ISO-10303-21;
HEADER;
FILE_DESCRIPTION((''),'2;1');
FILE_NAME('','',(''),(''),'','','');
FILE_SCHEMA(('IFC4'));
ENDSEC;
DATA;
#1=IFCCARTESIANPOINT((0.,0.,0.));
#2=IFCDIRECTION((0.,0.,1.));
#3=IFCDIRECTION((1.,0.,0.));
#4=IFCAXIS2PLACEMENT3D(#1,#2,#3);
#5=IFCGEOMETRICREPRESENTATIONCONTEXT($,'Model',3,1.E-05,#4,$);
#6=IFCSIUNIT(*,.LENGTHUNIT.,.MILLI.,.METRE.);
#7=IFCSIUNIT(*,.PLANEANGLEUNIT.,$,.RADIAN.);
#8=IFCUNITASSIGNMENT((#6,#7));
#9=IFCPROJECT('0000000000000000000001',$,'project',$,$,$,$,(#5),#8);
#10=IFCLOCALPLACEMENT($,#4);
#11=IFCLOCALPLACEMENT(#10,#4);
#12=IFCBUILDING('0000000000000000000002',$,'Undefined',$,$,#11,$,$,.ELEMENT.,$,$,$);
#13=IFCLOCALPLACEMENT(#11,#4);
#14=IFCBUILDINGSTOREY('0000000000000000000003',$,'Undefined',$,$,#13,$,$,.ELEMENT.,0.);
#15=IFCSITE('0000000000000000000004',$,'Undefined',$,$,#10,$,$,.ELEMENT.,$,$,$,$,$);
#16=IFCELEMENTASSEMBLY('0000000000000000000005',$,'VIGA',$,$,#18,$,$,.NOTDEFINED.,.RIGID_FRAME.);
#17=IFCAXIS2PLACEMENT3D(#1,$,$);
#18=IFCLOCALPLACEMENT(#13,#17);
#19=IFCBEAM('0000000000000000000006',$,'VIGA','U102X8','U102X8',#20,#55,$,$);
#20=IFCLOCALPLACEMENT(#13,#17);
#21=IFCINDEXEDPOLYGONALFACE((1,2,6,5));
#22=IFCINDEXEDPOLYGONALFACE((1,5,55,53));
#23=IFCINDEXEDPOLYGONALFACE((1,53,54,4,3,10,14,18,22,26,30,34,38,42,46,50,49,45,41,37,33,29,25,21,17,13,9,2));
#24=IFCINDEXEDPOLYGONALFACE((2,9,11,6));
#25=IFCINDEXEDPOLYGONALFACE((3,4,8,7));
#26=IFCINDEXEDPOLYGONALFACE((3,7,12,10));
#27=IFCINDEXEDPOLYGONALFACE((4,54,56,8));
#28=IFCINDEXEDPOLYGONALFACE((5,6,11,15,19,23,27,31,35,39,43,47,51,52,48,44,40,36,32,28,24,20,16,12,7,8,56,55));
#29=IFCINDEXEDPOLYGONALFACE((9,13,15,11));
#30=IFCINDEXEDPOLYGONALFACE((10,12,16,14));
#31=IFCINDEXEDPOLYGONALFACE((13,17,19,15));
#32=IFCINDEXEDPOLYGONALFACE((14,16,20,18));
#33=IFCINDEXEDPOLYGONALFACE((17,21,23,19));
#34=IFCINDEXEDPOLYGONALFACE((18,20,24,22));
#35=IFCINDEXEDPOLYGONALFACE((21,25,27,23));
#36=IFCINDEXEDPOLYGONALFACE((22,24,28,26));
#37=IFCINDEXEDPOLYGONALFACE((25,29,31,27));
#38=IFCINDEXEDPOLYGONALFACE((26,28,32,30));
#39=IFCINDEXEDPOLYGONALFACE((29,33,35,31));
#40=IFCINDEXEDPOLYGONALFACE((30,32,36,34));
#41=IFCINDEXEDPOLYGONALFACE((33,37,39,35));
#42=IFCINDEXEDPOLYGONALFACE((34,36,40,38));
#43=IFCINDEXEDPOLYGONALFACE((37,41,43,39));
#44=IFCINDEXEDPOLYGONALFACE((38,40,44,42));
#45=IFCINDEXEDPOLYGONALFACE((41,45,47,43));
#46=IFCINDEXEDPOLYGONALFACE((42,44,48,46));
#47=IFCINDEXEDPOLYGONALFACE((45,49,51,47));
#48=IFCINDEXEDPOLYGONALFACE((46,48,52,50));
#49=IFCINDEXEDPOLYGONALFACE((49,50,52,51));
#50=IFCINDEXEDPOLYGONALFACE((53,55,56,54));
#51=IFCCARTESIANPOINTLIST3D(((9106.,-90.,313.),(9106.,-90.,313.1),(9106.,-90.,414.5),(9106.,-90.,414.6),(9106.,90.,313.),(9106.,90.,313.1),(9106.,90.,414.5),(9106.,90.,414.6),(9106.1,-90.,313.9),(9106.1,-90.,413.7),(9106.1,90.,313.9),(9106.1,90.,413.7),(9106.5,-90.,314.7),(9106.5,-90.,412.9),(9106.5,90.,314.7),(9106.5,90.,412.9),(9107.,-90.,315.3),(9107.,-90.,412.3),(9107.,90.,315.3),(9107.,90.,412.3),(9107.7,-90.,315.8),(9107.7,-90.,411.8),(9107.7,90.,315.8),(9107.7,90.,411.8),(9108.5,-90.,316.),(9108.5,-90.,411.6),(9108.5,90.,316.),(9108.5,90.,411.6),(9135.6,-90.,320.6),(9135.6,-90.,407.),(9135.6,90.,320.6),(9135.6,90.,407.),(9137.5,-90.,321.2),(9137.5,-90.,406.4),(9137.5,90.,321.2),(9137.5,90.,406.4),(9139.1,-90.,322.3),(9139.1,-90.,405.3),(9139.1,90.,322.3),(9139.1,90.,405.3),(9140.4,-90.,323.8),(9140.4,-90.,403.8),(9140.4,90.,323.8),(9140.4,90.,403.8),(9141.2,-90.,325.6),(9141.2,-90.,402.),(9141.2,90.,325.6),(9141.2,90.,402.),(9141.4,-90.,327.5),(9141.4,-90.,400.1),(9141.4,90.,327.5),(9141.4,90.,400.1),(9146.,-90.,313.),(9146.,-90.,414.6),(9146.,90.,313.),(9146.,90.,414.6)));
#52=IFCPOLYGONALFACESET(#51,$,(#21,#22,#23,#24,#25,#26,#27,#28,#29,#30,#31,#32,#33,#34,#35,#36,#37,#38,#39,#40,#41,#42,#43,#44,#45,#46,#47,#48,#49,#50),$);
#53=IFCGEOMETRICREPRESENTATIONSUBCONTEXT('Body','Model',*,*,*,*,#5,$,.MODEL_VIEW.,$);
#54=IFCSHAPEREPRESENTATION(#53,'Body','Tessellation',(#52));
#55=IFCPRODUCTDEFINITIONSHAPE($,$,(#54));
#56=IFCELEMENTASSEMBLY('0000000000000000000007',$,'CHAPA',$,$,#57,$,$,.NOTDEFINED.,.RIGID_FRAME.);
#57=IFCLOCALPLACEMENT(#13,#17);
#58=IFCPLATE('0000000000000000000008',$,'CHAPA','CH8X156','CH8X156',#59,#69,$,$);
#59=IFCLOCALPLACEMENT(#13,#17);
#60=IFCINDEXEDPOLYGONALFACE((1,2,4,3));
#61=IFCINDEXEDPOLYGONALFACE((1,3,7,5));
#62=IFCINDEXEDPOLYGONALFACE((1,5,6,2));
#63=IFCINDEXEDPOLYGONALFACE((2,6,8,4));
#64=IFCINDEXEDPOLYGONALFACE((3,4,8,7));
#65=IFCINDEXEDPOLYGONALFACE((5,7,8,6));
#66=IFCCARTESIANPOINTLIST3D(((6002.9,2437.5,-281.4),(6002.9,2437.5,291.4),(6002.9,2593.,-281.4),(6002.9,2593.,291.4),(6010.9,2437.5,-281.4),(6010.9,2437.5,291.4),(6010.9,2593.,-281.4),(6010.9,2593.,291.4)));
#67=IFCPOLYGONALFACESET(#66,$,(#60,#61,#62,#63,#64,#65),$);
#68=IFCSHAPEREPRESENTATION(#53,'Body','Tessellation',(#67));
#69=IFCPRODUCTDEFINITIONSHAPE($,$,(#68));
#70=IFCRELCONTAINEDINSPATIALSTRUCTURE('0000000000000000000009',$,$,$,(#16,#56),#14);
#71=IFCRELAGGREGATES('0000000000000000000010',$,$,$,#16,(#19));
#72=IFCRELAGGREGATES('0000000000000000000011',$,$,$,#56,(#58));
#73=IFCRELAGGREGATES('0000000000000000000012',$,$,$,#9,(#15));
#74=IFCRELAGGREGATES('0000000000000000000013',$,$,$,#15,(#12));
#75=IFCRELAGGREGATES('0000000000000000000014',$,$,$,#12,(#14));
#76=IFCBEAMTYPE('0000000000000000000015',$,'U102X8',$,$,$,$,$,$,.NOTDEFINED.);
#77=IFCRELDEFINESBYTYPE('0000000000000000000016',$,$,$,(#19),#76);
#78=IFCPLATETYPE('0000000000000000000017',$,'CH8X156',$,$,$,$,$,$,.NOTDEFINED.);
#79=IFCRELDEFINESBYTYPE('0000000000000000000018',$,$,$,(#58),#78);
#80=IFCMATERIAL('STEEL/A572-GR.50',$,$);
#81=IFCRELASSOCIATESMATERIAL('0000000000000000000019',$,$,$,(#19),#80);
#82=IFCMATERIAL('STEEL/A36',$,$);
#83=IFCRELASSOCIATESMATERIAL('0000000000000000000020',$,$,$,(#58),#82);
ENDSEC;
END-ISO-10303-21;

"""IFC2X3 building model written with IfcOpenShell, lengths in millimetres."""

from ifc_helpers import new_model, si_unit, frame, origin_with_axes, origin_2d_with_axis, place, context, subcontext, project, spatial, polyline, u_section, outline, extrude, material, type_object, element, aggregate, save


model = new_model("IFC2X3")

# Units and contexts
model_context = context("Model", 3, precision=1e-05, world=origin_with_axes())
body_context = subcontext(model_context, "Body", "Model", "MODEL_VIEW")
ifc_project = project(units=[si_unit("LENGTHUNIT", "METRE", prefix="MILLI"), si_unit("PLANEANGLEUNIT", "RADIAN")], contexts=[model_context])

# Site, building, storey
site_placement = place(None, origin_with_axes())
site = spatial("IfcSite", under=ifc_project, at=site_placement, Name="Undefined", CompositionType="ELEMENT")
building_placement = place(site_placement, origin_with_axes())
building = spatial("IfcBuilding", under=site, at=building_placement, Name="Undefined", CompositionType="ELEMENT")
storey_placement = place(building_placement, origin_with_axes())
storey = spatial("IfcBuildingStorey", under=building, at=storey_placement, Name="Undefined", CompositionType="ELEMENT", Elevation=0.0)

# Element assembly, beam
ifc_material_1 = material(Name="STEEL/A572-GR.50")
beam_type = type_object("IfcBeamType", Name="U102X8", PredefinedType="NOTDEFINED")
assembly_1_placement = place(storey_placement, origin_with_axes())
assembly_1 = element("IfcElementAssembly", 1, at=assembly_1_placement, inside=storey, Name="VIGA", AssemblyPlace="NOTDEFINED", PredefinedType="RIGID_FRAME")
beam_1_placement = place(assembly_1_placement, frame((9126.0, 90.0, 363.8), z_axis=(0.0, 0.0, 1.0), x_axis=(0.0, -1.0, 0.0)))
beam_1 = element("IfcBeam", 2, at=beam_1_placement, type_object=beam_type, material=ifc_material_1, Name="VIGA", Description="U102X8", ObjectType="U102X8", context=body_context, shape_type="SweptSolid", body=[
    extrude(u_section(Depth=101.6, FlangeWidth=40.0, WebThickness=4.6, FlangeThickness=6.0, FilletRadius=7.0, EdgeRadius=3.0, FlangeSlope=0.16839, at=origin_2d_with_axis()), frame((180.0, 0.0, 0.0), z_axis=(-1.0, 0.0, 0.0), x_axis=(0.0, -1.0, 0.0)), (0.0, 0.0, 1.0), 180.0),
])
aggregate(assembly_1, [beam_1])

# Element assembly, plate
assembly_2_placement = place(storey_placement, origin_with_axes())
assembly_2 = element("IfcElementAssembly", 3, at=assembly_2_placement, inside=storey, Name="CHAPA", AssemblyPlace="NOTDEFINED", PredefinedType="RIGID_FRAME")
ifc_material_2 = material(Name="STEEL/A36")
plate_type = type_object("IfcPlateType", Name="CH8X156", PredefinedType="NOTDEFINED")
plate_placement = place(assembly_2_placement, frame((6006.9, 2593.0, 291.4), z_axis=(1.0, 0.0, 0.0), x_axis=(0.0, -1.0, 0.0)))
plate = element("IfcPlate", 4, at=plate_placement, type_object=plate_type, material=ifc_material_2, Name="CHAPA", Description="CH8X156", ObjectType="CH8X156", context=body_context, shape_type="SweptSolid", body=[
    extrude(outline(polyline([(0.0, 0.0), (155.5, 0.0), (155.5, 572.8), (0.0, 572.8), (0.0, 0.0)])), frame((0.0, 0.0, -4.0), z_axis=(0.0, 0.0, 1.0), x_axis=(1.0, 0.0, 0.0)), (0.0, 0.0, 1.0), 8.0),
])
aggregate(assembly_2, [plate])

save(model, "model.ifc")
